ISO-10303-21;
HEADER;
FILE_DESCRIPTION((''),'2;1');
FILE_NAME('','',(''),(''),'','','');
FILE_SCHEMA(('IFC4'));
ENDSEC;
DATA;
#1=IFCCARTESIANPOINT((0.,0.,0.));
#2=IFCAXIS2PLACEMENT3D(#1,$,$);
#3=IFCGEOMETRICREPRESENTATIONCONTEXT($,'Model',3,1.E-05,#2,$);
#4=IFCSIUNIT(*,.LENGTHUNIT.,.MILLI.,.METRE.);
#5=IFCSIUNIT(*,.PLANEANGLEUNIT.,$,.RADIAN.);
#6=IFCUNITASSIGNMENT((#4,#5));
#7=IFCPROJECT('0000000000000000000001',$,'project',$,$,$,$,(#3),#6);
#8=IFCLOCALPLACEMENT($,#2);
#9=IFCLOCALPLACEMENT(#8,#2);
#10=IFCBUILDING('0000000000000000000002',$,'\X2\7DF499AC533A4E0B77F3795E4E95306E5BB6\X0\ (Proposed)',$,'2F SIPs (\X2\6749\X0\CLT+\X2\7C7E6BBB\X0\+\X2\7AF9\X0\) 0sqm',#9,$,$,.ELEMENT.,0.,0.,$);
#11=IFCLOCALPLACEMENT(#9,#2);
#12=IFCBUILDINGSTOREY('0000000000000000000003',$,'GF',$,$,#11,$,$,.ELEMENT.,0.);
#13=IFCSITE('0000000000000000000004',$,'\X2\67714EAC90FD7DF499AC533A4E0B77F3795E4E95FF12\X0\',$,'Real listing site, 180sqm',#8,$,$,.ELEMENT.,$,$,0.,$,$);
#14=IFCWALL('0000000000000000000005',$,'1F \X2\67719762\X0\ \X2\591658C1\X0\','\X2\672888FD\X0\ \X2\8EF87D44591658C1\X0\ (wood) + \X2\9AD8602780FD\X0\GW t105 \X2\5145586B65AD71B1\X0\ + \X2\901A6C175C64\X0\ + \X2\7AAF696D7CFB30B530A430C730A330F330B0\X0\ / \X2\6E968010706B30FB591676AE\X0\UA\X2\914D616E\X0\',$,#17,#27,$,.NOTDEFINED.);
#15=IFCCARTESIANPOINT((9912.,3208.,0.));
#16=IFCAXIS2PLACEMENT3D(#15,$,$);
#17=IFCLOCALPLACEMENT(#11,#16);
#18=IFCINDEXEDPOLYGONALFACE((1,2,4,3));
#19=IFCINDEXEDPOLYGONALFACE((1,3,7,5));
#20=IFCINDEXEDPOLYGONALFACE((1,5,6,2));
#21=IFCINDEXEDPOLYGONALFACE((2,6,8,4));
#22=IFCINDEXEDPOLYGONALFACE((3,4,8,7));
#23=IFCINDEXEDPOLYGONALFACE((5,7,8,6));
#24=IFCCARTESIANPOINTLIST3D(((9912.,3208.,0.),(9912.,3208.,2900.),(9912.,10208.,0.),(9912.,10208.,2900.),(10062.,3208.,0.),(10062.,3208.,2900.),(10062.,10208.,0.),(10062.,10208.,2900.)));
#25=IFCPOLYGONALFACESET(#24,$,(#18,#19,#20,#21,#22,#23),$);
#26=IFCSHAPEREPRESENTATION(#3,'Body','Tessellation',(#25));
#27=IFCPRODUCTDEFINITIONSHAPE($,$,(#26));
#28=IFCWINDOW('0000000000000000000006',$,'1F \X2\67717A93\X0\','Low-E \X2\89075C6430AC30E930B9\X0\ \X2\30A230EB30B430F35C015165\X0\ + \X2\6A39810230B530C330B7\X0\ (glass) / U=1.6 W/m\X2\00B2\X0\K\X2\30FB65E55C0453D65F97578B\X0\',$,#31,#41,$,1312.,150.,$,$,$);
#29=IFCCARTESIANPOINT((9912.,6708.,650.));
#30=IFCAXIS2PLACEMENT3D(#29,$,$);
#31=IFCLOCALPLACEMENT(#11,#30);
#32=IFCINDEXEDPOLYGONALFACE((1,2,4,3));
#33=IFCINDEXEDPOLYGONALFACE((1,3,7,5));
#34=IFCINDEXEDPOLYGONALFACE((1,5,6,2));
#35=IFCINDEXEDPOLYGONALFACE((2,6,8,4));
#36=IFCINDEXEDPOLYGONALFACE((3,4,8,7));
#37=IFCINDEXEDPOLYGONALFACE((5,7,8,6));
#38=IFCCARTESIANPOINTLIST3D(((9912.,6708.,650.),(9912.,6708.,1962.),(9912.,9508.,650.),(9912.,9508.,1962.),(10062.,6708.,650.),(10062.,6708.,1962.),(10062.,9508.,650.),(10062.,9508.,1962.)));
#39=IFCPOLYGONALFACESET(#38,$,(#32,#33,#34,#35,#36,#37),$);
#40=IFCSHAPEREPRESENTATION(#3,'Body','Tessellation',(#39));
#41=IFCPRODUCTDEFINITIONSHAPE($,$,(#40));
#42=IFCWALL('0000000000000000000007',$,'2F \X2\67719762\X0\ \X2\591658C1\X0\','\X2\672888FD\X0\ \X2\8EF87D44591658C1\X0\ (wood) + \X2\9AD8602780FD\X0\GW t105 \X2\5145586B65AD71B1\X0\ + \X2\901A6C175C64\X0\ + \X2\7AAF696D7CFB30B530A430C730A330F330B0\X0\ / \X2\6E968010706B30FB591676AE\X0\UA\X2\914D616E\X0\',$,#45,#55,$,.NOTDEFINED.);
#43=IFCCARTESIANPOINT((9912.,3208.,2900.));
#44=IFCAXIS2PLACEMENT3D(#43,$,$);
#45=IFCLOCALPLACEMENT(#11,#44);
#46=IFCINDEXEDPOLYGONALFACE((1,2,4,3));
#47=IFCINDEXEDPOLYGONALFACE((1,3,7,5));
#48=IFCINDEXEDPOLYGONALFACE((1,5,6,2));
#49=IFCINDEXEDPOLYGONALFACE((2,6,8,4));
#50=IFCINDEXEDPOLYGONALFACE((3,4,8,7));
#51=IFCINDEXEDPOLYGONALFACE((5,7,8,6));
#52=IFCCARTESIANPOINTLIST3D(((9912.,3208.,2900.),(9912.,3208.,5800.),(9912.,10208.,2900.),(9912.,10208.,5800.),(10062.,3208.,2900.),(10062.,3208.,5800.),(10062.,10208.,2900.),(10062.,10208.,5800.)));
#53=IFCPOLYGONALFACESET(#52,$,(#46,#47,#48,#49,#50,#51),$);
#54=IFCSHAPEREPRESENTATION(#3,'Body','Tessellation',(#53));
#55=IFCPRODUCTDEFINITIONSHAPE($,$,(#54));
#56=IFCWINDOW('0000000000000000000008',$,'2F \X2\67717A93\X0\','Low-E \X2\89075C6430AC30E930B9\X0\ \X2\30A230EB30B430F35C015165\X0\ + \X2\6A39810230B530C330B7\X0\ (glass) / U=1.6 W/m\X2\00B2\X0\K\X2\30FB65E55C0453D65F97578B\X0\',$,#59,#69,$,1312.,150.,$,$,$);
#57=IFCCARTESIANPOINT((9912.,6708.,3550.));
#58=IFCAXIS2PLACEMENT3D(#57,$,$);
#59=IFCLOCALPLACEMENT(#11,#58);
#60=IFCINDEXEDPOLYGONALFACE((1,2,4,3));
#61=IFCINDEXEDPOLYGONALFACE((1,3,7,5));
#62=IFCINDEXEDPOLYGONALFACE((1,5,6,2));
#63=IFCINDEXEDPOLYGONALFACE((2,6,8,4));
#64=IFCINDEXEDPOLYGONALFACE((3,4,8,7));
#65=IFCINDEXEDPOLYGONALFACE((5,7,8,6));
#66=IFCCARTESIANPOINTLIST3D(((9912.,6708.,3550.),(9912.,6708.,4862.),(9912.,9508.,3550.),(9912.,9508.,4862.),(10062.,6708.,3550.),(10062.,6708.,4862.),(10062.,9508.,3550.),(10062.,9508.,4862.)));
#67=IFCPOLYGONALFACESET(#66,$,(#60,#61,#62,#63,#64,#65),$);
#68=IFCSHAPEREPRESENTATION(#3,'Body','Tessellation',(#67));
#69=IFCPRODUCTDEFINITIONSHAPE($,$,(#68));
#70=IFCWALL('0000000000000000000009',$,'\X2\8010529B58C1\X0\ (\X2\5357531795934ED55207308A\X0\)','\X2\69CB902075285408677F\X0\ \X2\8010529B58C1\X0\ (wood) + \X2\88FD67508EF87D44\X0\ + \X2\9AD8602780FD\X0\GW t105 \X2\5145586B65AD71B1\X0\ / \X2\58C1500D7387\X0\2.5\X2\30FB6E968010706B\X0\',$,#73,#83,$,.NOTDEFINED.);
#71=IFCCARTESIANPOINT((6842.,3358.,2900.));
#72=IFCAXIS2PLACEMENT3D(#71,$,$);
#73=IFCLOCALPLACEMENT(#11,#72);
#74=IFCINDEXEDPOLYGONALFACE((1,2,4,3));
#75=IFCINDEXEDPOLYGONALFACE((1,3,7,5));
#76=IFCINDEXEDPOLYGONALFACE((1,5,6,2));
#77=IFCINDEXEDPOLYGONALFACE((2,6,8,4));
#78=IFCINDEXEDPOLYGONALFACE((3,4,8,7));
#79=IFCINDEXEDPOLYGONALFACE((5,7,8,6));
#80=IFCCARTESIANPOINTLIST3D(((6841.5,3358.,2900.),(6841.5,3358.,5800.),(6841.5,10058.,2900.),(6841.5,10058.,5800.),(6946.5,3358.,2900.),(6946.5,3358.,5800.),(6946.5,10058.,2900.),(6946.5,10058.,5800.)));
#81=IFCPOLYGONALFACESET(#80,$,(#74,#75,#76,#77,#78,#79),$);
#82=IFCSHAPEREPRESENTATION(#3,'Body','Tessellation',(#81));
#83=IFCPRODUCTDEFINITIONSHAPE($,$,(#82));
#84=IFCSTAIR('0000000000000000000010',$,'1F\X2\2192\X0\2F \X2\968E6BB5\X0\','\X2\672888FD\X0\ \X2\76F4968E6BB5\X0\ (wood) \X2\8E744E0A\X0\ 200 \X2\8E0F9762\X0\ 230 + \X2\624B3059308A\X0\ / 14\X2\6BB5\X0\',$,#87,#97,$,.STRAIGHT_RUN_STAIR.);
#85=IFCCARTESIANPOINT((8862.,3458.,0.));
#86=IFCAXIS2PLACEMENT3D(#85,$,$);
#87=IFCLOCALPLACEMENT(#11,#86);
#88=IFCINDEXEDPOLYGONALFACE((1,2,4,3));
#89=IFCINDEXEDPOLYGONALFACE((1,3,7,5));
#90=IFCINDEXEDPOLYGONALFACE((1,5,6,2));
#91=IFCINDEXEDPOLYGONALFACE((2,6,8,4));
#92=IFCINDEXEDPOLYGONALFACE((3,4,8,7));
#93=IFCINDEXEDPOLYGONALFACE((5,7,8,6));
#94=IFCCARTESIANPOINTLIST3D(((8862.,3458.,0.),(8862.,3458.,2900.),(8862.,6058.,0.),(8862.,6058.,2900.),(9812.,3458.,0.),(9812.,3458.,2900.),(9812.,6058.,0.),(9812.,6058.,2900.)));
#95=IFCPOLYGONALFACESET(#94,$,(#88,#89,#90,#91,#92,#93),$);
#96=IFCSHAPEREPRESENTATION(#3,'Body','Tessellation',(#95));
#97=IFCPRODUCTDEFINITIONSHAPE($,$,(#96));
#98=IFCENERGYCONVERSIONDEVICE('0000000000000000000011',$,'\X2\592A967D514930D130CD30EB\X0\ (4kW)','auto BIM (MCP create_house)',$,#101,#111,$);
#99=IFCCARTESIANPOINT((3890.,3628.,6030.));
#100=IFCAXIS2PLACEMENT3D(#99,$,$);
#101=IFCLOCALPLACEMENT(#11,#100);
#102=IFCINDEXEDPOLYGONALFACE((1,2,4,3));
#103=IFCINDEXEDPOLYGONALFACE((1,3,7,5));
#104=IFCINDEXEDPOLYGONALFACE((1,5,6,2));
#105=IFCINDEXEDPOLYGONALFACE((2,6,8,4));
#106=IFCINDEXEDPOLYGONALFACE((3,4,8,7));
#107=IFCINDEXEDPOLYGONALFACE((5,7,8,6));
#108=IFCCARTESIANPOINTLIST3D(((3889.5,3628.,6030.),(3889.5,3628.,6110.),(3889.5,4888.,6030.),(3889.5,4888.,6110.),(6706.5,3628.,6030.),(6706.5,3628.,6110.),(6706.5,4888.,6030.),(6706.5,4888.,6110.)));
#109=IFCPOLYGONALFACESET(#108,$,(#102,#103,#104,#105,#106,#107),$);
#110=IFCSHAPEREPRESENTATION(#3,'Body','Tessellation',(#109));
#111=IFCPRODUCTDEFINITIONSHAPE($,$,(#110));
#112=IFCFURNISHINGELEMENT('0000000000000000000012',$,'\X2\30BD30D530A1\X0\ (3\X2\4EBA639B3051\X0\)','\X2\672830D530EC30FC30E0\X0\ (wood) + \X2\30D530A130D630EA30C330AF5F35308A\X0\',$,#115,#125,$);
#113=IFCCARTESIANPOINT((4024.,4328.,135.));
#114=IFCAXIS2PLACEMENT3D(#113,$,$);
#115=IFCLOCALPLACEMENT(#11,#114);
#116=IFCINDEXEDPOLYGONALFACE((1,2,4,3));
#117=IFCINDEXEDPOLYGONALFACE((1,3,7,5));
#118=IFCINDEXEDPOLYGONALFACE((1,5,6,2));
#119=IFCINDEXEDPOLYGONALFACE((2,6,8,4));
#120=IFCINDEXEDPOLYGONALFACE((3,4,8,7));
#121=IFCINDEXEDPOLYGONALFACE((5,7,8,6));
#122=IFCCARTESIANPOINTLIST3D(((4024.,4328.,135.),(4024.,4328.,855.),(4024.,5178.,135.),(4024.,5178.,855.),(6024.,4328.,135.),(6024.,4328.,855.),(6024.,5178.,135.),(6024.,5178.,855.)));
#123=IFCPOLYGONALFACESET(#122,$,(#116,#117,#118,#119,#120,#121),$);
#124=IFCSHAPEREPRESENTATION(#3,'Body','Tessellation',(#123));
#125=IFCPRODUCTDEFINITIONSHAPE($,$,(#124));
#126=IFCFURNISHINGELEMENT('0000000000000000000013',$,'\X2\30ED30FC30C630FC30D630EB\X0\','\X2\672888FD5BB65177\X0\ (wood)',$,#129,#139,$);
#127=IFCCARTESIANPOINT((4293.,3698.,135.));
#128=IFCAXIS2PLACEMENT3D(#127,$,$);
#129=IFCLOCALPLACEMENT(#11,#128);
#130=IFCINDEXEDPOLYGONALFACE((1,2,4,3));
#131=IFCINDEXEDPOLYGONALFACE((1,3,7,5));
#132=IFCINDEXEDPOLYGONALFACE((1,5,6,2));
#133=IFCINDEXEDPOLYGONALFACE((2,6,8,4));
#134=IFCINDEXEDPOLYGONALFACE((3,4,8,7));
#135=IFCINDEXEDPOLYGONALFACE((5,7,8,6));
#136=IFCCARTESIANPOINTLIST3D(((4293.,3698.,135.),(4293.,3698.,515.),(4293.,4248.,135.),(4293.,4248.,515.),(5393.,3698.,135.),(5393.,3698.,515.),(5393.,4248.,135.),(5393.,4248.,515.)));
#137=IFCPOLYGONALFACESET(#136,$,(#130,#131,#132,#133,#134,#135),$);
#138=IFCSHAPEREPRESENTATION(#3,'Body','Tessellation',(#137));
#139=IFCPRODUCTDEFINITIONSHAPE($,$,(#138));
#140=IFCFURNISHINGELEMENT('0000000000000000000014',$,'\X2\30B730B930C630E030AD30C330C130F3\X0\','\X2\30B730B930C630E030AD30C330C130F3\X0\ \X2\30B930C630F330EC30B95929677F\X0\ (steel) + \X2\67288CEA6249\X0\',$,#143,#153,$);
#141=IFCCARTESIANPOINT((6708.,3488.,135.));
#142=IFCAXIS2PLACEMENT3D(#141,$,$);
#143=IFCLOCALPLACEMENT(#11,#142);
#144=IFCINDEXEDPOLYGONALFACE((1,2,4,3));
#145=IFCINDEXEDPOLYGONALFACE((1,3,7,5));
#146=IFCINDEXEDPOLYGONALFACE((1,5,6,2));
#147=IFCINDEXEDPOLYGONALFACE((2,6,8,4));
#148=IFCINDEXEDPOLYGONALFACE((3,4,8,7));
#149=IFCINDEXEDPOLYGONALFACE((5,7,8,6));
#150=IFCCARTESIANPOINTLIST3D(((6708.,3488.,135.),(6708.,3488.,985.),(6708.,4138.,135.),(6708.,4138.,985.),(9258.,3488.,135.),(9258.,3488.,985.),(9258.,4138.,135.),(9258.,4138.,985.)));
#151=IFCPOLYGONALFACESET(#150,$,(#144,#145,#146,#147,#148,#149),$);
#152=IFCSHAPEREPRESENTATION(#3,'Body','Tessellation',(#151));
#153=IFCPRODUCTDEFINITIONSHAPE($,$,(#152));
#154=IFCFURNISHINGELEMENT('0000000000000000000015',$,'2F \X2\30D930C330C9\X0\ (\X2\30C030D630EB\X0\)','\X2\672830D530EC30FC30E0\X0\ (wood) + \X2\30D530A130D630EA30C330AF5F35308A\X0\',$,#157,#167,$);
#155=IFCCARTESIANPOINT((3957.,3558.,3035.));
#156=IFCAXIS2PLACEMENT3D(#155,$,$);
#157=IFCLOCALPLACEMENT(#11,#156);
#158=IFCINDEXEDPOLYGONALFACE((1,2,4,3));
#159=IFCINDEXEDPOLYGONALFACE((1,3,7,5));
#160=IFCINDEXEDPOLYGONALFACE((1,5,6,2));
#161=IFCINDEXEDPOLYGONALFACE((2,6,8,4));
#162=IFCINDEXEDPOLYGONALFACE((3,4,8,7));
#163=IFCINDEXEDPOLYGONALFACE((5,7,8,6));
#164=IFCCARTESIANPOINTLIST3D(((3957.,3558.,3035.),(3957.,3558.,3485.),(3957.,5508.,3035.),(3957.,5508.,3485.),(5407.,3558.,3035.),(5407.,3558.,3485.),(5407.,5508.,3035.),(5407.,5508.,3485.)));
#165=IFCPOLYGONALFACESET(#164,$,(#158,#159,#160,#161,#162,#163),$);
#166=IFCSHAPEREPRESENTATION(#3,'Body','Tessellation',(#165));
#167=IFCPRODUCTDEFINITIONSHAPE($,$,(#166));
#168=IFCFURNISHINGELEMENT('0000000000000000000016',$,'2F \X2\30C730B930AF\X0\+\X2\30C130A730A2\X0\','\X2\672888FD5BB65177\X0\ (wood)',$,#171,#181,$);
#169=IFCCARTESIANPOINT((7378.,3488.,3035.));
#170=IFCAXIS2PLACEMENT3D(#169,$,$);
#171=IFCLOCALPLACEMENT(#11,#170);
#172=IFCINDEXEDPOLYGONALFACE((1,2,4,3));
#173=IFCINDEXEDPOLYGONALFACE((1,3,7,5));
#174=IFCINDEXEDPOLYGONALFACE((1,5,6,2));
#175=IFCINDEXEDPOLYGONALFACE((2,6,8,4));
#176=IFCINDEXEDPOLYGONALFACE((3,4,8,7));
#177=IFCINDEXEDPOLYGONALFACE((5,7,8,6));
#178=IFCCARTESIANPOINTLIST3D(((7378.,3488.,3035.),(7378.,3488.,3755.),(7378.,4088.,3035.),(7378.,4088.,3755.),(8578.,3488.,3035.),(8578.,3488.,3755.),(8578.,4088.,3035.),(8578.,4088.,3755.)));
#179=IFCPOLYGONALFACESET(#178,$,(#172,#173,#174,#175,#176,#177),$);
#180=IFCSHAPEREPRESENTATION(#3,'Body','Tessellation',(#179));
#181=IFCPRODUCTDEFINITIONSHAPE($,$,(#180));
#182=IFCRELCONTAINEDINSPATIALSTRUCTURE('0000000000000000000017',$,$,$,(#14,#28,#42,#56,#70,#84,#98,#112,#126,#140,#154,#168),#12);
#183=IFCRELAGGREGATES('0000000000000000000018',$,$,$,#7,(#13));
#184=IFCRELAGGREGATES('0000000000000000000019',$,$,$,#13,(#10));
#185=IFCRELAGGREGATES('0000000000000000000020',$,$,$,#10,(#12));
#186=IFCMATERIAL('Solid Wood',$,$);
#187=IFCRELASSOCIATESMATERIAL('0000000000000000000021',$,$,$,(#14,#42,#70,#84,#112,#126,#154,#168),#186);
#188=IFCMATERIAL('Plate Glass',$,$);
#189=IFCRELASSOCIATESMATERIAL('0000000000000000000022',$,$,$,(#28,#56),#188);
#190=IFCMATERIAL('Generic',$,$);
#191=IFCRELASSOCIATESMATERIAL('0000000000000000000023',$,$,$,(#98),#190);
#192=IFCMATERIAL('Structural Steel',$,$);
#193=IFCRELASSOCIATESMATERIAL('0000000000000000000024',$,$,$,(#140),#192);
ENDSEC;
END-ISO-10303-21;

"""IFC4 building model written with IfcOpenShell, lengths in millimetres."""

from ifc_helpers import new_model, si_unit, frame, frame_2d, origin, place, context, project, spatial, rectangle, extrude, material, element, fill, save


model = new_model("IFC4")

# Units and contexts
model_context = context("Model", 3, precision=1e-05, world=origin())
ifc_project = project(units=[si_unit("LENGTHUNIT", "METRE", prefix="MILLI"), si_unit("PLANEANGLEUNIT", "RADIAN")], contexts=[model_context])

# Site, building, storey
site_placement = place(None, origin())
site = spatial("IfcSite", under=ifc_project, at=site_placement, Name="東京都練馬区下石神井２", ObjectType="Real listing site, 180sqm", CompositionType="ELEMENT", RefElevation=0.0)
building_placement = place(site_placement, origin())
building = spatial("IfcBuilding", under=site, at=building_placement, Name="練馬区下石神井の家 (Proposed)", ObjectType="2F SIPs (杉CLT+籾殻+竹) 0sqm", CompositionType="ELEMENT", ElevationOfRefHeight=0.0, ElevationOfTerrain=0.0)
storey_placement = place(building_placement, origin())
storey = spatial("IfcBuildingStorey", under=building, at=storey_placement, Name="GF", CompositionType="ELEMENT", Elevation=0.0)

# Wall, opening, window
ifc_material_1 = material(Name="Solid Wood")
wall_1_placement = place(storey_placement, frame((9912.0, 3208.0, 0.0)))
wall_1 = element("IfcWall", 1, at=wall_1_placement, inside=storey, material=ifc_material_1, Name="1F 東面 外壁", Description="木製 軸組外壁 (wood) + 高性能GW t105 充填断熱 + 通気層 + 窯業系サイディング / 準耐火・外皮UA配慮", PredefinedType="NOTDEFINED", context=model_context, shape_type="SweptSolid", body=[
    extrude(rectangle(XDim=150.0, YDim=7000.0, at=frame_2d((75.0, 3500.0))), frame((9912.0, 3208.0, 0.0)), (0.0, 0.0, 1.0), 2900.0),
])
opening_1_placement = place(storey_placement, frame((9912.0, 6708.0, 650.0)))
opening_1 = element("IfcOpeningElement", 2, at=opening_1_placement, cuts=wall_1, PredefinedType="NOTDEFINED", context=model_context, shape_type="SweptSolid", body=[
    extrude(rectangle(XDim=150.0, YDim=2800.0, at=frame_2d((75.0, 1400.0))), frame((9912.0, 6708.0, 650.0)), (0.0, 0.0, 1.0), 1312.0),
])
ifc_material_2 = material(Name="Plate Glass")
window_1_placement = place(storey_placement, frame((9912.0, 6708.0, 650.0)))
window_1 = element("IfcWindow", 3, at=window_1_placement, inside=storey, material=ifc_material_2, Name="1F 東窓", Description="Low-E 複層ガラス アルゴン封入 + 樹脂サッシ (glass) / U=1.6 W/m²K・日射取得型", OverallHeight=1312.0, OverallWidth=150.0, context=model_context, shape_type="SweptSolid", body=[
    extrude(rectangle(XDim=150.0, YDim=2800.0, at=frame_2d((75.0, 1400.0))), frame((9912.0, 6708.0, 650.0)), (0.0, 0.0, 1.0), 1312.0),
])
fill(opening_1, window_1)

# Wall, opening, window
wall_2_placement = place(storey_placement, frame((9912.0, 3208.0, 2900.0)))
wall_2 = element("IfcWall", 4, at=wall_2_placement, inside=storey, material=ifc_material_1, Name="2F 東面 外壁", Description="木製 軸組外壁 (wood) + 高性能GW t105 充填断熱 + 通気層 + 窯業系サイディング / 準耐火・外皮UA配慮", PredefinedType="NOTDEFINED", context=model_context, shape_type="SweptSolid", body=[
    extrude(rectangle(XDim=150.0, YDim=7000.0, at=frame_2d((75.0, 3500.0))), frame((9912.0, 3208.0, 2900.0)), (0.0, 0.0, 1.0), 2900.0),
])
opening_2_placement = place(storey_placement, frame((9912.0, 6708.0, 3550.0)))
opening_2 = element("IfcOpeningElement", 5, at=opening_2_placement, cuts=wall_2, PredefinedType="NOTDEFINED", context=model_context, shape_type="SweptSolid", body=[
    extrude(rectangle(XDim=150.0, YDim=2800.0, at=frame_2d((75.0, 1400.0))), frame((9912.0, 6708.0, 3550.0)), (0.0, 0.0, 1.0), 1312.0),
])
window_2_placement = place(storey_placement, frame((9912.0, 6708.0, 3550.0)))
window_2 = element("IfcWindow", 6, at=window_2_placement, inside=storey, material=ifc_material_2, Name="2F 東窓", Description="Low-E 複層ガラス アルゴン封入 + 樹脂サッシ (glass) / U=1.6 W/m²K・日射取得型", OverallHeight=1312.0, OverallWidth=150.0, context=model_context, shape_type="SweptSolid", body=[
    extrude(rectangle(XDim=150.0, YDim=2800.0, at=frame_2d((75.0, 1400.0))), frame((9912.0, 6708.0, 3550.0)), (0.0, 0.0, 1.0), 1312.0),
])
fill(opening_2, window_2)

# Wall
wall_3_placement = place(storey_placement, frame((6842.0, 3358.0, 2900.0)))
element("IfcWall", 7, at=wall_3_placement, inside=storey, material=ifc_material_1, Name="耐力壁 (南北間仕切り)", Description="構造用合板 耐力壁 (wood) + 製材軸組 + 高性能GW t105 充填断熱 / 壁倍率2.5・準耐火", PredefinedType="NOTDEFINED", context=model_context, shape_type="SweptSolid", body=[
    extrude(rectangle(XDim=105.0, YDim=6700.0, at=frame_2d((52.0, 3350.0))), frame((6842.0, 3358.0, 2900.0)), (0.0, 0.0, 1.0), 2900.0),
])

# Stair
stair_placement = place(storey_placement, frame((8862.0, 3458.0, 0.0)))
element("IfcStair", 8, at=stair_placement, inside=storey, material=ifc_material_1, Name="1F→2F 階段", Description="木製 直階段 (wood) 蹴上 200 踏面 230 + 手すり / 14段", PredefinedType="STRAIGHT_RUN_STAIR", context=model_context, shape_type="SweptSolid", body=[
    extrude(rectangle(XDim=950.0, YDim=2600.0, at=frame_2d((475.0, 1300.0))), frame((8862.0, 3458.0, 0.0)), (0.0, 0.0, 1.0), 2900.0),
])

# Energy conversion device
ifc_material_3 = material(Name="Generic")
energy_conversion_device_placement = place(storey_placement, frame((3890.0, 3628.0, 6030.0)))
element("IfcEnergyConversionDevice", 9, at=energy_conversion_device_placement, inside=storey, material=ifc_material_3, Name="太陽光パネル (4kW)", Description="auto BIM (MCP create_house)", context=model_context, shape_type="SweptSolid", body=[
    extrude(rectangle(XDim=2817.0, YDim=1260.0, at=frame_2d((1408.0, 630.0))), frame((3890.0, 3628.0, 6030.0)), (0.0, 0.0, 1.0), 80.0),
])

# Furnishing elements
furnishing_1_placement = place(storey_placement, frame((4024.0, 4328.0, 135.0)))
element("IfcFurnishingElement", 10, at=furnishing_1_placement, inside=storey, material=ifc_material_1, Name="ソファ (3人掛け)", Description="木フレーム (wood) + ファブリック張り", context=model_context, shape_type="SweptSolid", body=[
    extrude(rectangle(XDim=2000.0, YDim=850.0, at=frame_2d((1000.0, 425.0))), frame((4024.0, 4328.0, 135.0)), (0.0, 0.0, 1.0), 720.0),
])
furnishing_2_placement = place(storey_placement, frame((4293.0, 3698.0, 135.0)))
element("IfcFurnishingElement", 11, at=furnishing_2_placement, inside=storey, material=ifc_material_1, Name="ローテーブル", Description="木製家具 (wood)", context=model_context, shape_type="SweptSolid", body=[
    extrude(rectangle(XDim=1100.0, YDim=550.0, at=frame_2d((550.0, 275.0))), frame((4293.0, 3698.0, 135.0)), (0.0, 0.0, 1.0), 380.0),
])
ifc_material_4 = material(Name="Structural Steel")
furnishing_3_placement = place(storey_placement, frame((6708.0, 3488.0, 135.0)))
element("IfcFurnishingElement", 12, at=furnishing_3_placement, inside=storey, material=ifc_material_4, Name="システムキッチン", Description="システムキッチン ステンレス天板 (steel) + 木質扉", context=model_context, shape_type="SweptSolid", body=[
    extrude(rectangle(XDim=2550.0, YDim=650.0, at=frame_2d((1275.0, 325.0))), frame((6708.0, 3488.0, 135.0)), (0.0, 0.0, 1.0), 850.0),
])
furnishing_4_placement = place(storey_placement, frame((3957.0, 3558.0, 3035.0)))
element("IfcFurnishingElement", 13, at=furnishing_4_placement, inside=storey, material=ifc_material_1, Name="2F ベッド (ダブル)", Description="木フレーム (wood) + ファブリック張り", context=model_context, shape_type="SweptSolid", body=[
    extrude(rectangle(XDim=1450.0, YDim=1950.0, at=frame_2d((725.0, 975.0))), frame((3957.0, 3558.0, 3035.0)), (0.0, 0.0, 1.0), 450.0),
])
furnishing_5_placement = place(storey_placement, frame((7378.0, 3488.0, 3035.0)))
element("IfcFurnishingElement", 14, at=furnishing_5_placement, inside=storey, material=ifc_material_1, Name="2F デスク+チェア", Description="木製家具 (wood)", context=model_context, shape_type="SweptSolid", body=[
    extrude(rectangle(XDim=1200.0, YDim=600.0, at=frame_2d((600.0, 300.0))), frame((7378.0, 3488.0, 3035.0)), (0.0, 0.0, 1.0), 720.0),
])

save(model, "model.ifc")
